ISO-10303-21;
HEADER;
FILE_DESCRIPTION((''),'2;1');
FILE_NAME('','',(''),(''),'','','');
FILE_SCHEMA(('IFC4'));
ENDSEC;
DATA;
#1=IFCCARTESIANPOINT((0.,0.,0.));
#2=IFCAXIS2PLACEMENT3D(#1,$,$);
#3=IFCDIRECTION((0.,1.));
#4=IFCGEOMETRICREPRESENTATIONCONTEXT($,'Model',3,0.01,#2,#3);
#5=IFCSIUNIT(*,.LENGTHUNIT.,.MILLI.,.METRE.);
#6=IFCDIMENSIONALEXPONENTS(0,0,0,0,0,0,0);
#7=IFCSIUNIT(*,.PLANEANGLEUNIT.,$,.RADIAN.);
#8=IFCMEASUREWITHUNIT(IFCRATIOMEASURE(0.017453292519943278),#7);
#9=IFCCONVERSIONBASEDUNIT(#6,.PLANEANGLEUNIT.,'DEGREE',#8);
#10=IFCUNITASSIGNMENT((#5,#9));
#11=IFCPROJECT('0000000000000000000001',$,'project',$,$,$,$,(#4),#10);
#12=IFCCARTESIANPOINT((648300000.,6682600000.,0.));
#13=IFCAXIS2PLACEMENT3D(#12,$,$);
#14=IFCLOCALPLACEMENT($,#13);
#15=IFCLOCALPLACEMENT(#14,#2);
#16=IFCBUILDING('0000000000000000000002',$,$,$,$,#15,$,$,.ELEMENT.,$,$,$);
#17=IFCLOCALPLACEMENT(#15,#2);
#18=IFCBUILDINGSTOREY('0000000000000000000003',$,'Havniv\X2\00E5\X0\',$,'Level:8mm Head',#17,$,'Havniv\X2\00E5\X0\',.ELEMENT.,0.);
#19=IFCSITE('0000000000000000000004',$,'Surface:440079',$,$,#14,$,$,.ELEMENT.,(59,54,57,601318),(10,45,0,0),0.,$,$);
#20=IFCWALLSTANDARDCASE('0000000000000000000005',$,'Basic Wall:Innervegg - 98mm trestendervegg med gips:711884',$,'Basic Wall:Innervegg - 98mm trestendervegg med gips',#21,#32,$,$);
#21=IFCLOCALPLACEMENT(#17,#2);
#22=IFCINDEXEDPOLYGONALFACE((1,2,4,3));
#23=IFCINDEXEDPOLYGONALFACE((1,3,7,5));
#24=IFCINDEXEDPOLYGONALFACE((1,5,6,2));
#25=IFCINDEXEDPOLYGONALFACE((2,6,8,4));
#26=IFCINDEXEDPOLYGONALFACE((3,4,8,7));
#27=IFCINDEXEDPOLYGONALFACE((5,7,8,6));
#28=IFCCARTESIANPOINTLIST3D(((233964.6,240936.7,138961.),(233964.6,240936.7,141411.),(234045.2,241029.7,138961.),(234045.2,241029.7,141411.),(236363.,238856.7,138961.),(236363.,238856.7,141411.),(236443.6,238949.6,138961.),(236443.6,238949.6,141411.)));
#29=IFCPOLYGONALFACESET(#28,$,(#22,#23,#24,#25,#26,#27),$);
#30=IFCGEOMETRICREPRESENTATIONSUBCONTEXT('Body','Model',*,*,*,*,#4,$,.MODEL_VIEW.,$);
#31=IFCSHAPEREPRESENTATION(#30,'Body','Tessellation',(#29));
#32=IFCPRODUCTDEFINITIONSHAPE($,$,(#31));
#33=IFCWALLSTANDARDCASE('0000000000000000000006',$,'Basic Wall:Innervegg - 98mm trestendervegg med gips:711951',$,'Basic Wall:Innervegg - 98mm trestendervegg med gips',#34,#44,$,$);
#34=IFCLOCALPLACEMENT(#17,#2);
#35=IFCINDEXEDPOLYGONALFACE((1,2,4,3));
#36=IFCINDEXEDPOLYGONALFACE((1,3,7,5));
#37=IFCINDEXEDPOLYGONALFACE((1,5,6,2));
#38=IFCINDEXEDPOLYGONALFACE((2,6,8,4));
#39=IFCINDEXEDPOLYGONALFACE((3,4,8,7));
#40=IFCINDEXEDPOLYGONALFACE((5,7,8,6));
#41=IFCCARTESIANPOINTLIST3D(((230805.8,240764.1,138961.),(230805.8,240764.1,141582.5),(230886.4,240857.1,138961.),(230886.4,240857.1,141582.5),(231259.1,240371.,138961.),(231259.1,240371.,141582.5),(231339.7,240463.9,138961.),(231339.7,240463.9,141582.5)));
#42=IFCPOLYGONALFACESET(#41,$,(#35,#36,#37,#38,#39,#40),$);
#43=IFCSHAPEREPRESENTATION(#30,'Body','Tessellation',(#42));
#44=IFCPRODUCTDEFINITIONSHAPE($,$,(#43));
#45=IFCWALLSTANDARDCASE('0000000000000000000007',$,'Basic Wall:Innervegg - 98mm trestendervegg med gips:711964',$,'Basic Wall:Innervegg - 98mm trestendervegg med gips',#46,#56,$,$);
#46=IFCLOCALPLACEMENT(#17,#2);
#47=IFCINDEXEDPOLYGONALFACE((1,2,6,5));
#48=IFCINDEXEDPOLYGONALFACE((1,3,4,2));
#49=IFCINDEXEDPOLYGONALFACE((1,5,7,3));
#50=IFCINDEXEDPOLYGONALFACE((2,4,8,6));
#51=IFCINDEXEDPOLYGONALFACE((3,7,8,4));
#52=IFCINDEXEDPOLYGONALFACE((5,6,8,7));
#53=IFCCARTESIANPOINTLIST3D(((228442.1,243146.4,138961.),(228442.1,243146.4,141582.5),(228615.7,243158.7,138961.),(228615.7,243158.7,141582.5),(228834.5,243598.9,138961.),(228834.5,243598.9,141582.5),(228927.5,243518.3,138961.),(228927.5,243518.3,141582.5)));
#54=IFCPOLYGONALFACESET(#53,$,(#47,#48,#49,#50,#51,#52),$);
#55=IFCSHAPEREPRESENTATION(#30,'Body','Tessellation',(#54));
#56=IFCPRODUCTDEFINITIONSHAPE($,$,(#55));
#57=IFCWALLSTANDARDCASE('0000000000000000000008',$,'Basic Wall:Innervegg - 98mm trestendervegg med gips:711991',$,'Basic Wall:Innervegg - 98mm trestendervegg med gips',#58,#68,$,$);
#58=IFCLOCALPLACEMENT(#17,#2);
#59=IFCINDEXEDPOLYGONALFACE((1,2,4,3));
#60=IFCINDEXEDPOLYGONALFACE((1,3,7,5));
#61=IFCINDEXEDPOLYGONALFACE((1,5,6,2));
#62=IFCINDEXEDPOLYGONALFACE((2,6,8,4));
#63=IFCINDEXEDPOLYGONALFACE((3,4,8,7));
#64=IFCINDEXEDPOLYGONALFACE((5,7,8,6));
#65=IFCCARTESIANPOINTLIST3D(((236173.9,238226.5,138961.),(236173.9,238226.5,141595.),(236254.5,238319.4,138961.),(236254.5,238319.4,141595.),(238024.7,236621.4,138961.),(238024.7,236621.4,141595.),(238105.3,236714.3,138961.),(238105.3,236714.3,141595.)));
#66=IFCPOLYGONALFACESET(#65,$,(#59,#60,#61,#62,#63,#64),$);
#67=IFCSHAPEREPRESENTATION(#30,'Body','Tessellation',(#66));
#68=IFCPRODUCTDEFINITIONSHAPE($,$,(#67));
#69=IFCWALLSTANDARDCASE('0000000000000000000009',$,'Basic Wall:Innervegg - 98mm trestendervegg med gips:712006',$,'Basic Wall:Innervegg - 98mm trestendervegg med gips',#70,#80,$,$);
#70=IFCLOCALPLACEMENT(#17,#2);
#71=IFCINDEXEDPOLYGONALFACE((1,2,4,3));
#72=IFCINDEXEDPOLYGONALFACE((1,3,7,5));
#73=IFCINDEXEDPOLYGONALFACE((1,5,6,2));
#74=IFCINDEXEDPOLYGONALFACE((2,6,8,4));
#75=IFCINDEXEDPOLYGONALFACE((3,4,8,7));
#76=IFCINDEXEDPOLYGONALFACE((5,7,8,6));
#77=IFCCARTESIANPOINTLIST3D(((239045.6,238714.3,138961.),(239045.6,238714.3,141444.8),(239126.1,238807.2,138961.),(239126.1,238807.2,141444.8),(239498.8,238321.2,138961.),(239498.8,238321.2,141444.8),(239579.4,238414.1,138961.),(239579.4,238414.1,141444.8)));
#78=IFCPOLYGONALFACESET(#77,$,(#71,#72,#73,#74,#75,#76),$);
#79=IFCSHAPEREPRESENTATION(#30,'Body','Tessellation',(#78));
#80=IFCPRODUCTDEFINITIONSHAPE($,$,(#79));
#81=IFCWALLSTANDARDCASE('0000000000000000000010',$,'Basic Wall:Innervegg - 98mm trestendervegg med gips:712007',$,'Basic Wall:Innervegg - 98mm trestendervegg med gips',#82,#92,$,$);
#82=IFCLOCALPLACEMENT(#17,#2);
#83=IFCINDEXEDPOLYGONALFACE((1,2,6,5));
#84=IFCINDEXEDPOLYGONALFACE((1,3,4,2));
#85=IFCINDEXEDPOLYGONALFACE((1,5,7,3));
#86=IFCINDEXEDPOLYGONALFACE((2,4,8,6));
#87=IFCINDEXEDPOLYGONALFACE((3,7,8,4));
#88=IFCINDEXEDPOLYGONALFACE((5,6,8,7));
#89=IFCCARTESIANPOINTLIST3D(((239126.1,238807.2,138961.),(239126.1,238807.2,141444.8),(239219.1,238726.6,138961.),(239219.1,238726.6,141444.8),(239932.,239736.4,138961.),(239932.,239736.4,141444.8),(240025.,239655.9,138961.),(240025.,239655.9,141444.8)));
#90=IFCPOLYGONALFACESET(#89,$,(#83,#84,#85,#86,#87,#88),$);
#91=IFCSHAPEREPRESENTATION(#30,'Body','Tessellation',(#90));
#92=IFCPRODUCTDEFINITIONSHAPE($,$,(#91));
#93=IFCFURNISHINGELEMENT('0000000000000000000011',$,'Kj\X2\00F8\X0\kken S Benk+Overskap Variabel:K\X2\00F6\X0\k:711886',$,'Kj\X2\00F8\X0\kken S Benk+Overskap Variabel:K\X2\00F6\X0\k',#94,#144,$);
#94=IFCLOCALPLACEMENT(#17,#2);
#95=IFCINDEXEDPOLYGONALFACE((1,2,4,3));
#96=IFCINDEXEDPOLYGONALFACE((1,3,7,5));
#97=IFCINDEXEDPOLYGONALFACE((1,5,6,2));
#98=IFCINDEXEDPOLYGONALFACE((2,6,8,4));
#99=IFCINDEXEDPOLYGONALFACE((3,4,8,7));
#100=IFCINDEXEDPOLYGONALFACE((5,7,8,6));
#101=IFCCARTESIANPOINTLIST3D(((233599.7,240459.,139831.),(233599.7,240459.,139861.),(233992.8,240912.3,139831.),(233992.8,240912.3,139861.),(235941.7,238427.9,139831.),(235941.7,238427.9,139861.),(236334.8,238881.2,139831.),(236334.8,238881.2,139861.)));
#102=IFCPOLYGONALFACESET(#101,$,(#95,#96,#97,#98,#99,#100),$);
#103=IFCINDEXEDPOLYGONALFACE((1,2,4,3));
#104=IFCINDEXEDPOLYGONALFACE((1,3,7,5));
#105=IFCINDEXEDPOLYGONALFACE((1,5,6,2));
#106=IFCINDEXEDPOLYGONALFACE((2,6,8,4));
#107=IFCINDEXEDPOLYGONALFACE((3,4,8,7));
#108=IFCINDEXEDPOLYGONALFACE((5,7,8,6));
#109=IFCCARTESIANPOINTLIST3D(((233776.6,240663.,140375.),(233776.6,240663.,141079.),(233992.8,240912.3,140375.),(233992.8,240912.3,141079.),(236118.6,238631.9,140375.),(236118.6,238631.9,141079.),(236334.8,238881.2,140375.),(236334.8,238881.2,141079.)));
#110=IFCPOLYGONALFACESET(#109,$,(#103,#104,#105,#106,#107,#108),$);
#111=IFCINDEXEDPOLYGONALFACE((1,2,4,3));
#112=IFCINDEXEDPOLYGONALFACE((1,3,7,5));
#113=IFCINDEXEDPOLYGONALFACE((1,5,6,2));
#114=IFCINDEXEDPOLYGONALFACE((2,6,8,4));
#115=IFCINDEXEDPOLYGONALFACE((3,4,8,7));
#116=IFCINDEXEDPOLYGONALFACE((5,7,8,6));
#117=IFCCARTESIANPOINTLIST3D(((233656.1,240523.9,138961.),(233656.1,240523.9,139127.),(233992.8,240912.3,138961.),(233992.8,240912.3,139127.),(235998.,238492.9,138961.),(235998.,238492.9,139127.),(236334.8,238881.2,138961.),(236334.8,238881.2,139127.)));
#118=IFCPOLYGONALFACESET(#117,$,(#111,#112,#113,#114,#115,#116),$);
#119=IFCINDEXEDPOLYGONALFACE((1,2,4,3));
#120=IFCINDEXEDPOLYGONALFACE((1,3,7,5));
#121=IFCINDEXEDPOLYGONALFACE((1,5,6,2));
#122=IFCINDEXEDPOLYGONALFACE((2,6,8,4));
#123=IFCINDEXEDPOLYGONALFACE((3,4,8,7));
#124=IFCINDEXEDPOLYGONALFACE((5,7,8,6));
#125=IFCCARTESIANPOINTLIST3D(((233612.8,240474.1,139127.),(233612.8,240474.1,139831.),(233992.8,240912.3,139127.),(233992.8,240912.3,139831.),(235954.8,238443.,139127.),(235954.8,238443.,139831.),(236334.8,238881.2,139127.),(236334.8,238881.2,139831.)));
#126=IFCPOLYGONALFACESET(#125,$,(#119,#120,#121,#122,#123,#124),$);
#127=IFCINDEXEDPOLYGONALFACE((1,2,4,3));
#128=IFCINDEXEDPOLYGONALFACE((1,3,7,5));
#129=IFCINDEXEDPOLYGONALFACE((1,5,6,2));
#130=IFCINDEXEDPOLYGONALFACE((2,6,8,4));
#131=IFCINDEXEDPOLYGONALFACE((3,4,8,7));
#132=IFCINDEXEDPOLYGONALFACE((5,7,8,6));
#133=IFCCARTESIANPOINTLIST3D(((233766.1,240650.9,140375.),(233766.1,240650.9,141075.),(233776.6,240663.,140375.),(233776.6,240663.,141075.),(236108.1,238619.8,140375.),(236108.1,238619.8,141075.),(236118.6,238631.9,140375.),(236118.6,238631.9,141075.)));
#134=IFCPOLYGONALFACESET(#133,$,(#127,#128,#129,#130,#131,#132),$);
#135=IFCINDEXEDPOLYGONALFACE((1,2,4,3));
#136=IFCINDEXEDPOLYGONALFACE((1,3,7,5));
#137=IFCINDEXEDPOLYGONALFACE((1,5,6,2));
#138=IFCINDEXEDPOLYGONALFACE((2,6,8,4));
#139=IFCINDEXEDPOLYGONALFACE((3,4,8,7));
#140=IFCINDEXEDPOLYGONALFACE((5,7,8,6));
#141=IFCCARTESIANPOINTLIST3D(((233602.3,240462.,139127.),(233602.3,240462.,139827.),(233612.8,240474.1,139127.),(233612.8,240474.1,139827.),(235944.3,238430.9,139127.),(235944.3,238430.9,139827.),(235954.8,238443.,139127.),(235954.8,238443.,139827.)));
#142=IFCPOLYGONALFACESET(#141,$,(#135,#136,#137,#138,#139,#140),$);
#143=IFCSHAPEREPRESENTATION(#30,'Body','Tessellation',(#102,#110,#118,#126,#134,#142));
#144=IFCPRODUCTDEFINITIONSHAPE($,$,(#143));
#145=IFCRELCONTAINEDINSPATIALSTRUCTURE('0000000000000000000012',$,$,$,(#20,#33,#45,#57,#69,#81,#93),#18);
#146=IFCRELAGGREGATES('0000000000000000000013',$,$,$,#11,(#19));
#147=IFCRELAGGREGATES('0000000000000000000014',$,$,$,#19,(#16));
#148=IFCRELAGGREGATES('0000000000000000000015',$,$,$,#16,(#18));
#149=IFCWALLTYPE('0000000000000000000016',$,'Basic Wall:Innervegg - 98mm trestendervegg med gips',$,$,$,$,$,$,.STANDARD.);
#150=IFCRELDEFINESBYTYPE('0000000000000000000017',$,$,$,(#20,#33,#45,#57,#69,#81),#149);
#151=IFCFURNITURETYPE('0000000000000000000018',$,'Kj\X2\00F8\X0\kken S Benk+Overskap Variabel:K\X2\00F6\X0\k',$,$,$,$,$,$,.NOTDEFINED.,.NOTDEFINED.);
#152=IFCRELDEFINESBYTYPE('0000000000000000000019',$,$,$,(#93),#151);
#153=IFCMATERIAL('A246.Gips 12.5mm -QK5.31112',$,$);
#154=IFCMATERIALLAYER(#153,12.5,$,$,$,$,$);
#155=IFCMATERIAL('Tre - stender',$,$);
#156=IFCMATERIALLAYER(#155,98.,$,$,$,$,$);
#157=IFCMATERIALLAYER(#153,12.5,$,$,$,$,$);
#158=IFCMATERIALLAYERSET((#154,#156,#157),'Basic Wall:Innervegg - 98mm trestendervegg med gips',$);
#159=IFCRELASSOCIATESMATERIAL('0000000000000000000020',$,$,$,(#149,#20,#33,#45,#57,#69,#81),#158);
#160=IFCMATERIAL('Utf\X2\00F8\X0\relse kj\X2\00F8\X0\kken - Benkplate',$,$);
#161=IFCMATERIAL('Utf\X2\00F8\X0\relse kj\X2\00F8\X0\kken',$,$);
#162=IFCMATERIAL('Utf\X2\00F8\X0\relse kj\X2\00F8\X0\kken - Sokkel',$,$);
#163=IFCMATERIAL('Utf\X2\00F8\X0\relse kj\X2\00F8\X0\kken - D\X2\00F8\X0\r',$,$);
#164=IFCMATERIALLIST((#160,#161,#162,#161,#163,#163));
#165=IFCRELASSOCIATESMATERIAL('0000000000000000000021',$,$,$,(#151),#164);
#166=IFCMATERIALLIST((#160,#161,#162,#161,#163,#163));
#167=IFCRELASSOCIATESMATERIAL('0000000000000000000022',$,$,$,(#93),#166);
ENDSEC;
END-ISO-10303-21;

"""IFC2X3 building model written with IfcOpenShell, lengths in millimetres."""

from ifc_helpers import new_model, entity, si_unit, converted_unit, direction, frame, frame_2d, origin, origin_2d_with_axis, place, context, subcontext, project, spatial, polyline, rectangle, outline, extrude, source, transform, mapped, material, material_list, layer, layer_set, layer_usage, type_object, type_shapes, element, save


model = new_model("IFC2X3")

# Units and contexts
model_context = context("Model", 3, precision=0.01, world=origin(), true_north=direction((0.0, 1.0)))
body_context = subcontext(model_context, "Body", "Model", "MODEL_VIEW")
ifc_project = project(units=[si_unit("LENGTHUNIT", "METRE", prefix="MILLI"), converted_unit("PLANEANGLEUNIT", "DEGREE", entity("IfcRatioMeasure", 0.017453292519943278), si_unit("PLANEANGLEUNIT", "RADIAN"), dimensions=[0, 0, 0, 0, 0, 0, 0])], contexts=[model_context])

# Site, building, storey
site_placement = place(None, frame((648300000.0, 6682600000.0, 0.0)))
site = spatial("IfcSite", under=ifc_project, at=site_placement, Name="Surface:440079", CompositionType="ELEMENT", RefLatitude=(59, 54, 57, 601318), RefLongitude=(10, 45, 0, 0), RefElevation=0.0)
building_placement = place(site_placement, origin())
building = spatial("IfcBuilding", under=site, at=building_placement, CompositionType="ELEMENT")
storey_placement = place(building_placement, origin())
storey = spatial("IfcBuildingStorey", under=building, at=storey_placement, Name="Havnivå", ObjectType="Level:8mm Head", LongName="Havnivå", CompositionType="ELEMENT", Elevation=0.0)

# Shared definitions
ifc_material_1 = material(Name="A246.Gips 12.5mm -QK5.31112")
ifc_layer_1 = layer(ifc_material_1, 12.5)
ifc_material_2 = material(Name="Tre - stender")
ifc_layer_2 = layer(ifc_material_2, 98.0)
ifc_layer_3 = layer(ifc_material_1, 12.5)
ifc_layer_set = layer_set([ifc_layer_1, ifc_layer_2, ifc_layer_3], Name="Basic Wall:Innervegg - 98mm trestendervegg med gips")
wall_type = type_object("IfcWallType", Name="Basic Wall:Innervegg - 98mm trestendervegg med gips", PredefinedType="STANDARD", material=ifc_layer_set)

# Walls
ifc_layer_usage_1 = layer_usage(ifc_layer_set, "AXIS2", "NEGATIVE", 61.5)
wall_1_placement = place(storey_placement, frame((234004.9, 240983.2, 138961.0), z_axis=(0.0, 0.0, 1.0), x_axis=(0.755467, -0.655187, 0.0)))
element("IfcWallStandardCase", 1, at=wall_1_placement, inside=storey, type_object=wall_type, material=ifc_layer_usage_1, Name="Basic Wall:Innervegg - 98mm trestendervegg med gips:711884", ObjectType="Basic Wall:Innervegg - 98mm trestendervegg med gips", context=body_context, shape_type="SweptSolid", body=[
    extrude(rectangle(XDim=3174.7, YDim=123.0, at=frame_2d((1587.4, 0.0), x_axis=(-1.0, 0.0))), origin(), (0.0, 0.0, 1.0), 2450.0),
])
ifc_layer_usage_2 = layer_usage(ifc_layer_set, "AXIS2", "NEGATIVE", 61.5)
wall_2_placement = place(storey_placement, frame((231299.4, 240417.5, 138961.0), z_axis=(0.0, 0.0, 1.0), x_axis=(-0.755467, 0.655187, 0.0)))
element("IfcWallStandardCase", 2, at=wall_2_placement, inside=storey, type_object=wall_type, material=ifc_layer_usage_2, Name="Basic Wall:Innervegg - 98mm trestendervegg med gips:711951", ObjectType="Basic Wall:Innervegg - 98mm trestendervegg med gips", context=body_context, shape_type="SweptSolid", body=[
    extrude(rectangle(XDim=600.0, YDim=123.0, at=frame_2d((300.0, 0.0), x_axis=(-1.0, 0.0))), origin(), (0.0, 0.0, 1.0), 2621.5),
])
ifc_layer_usage_3 = layer_usage(ifc_layer_set, "AXIS2", "NEGATIVE", 61.5)
wall_3_placement = place(storey_placement, frame((228881.0, 243558.6, 138961.0), z_axis=(0.0, 0.0, 1.0), x_axis=(-0.655187, -0.755467, 0.0)))
element("IfcWallStandardCase", 3, at=wall_3_placement, inside=storey, type_object=wall_type, material=ifc_layer_usage_3, Name="Basic Wall:Innervegg - 98mm trestendervegg med gips:711964", ObjectType="Basic Wall:Innervegg - 98mm trestendervegg med gips", context=body_context, shape_type="SweptSolid", body=[
    extrude(outline(polyline([(598.9, -61.5), (475.9, 61.5), (0.0, 61.5), (0.0, -61.5), (598.9, -61.5)])), origin(), (0.0, 0.0, 1.0), 2621.5),
])
ifc_layer_usage_4 = layer_usage(ifc_layer_set, "AXIS2", "NEGATIVE", 61.5)
wall_4_placement = place(storey_placement, frame((238065.0, 236667.8, 138961.0), z_axis=(0.0, 0.0, 1.0), x_axis=(-0.755467, 0.655187, 0.0)))
element("IfcWallStandardCase", 4, at=wall_4_placement, inside=storey, type_object=wall_type, material=ifc_layer_usage_4, Name="Basic Wall:Innervegg - 98mm trestendervegg med gips:711991", ObjectType="Basic Wall:Innervegg - 98mm trestendervegg med gips", context=body_context, shape_type="SweptSolid", body=[
    extrude(rectangle(XDim=2449.9, YDim=123.0, at=frame_2d((1224.9, 0.0), x_axis=(-1.0, 0.0))), origin(), (0.0, 0.0, 1.0), 2634.0),
])

# Walls
ifc_layer_usage_5 = layer_usage(ifc_layer_set, "AXIS2", "POSITIVE", -61.5)
wall_5_placement = place(storey_placement, frame((239539.1, 238367.6, 138961.0), z_axis=(0.0, 0.0, 1.0), x_axis=(-0.755467, 0.655187, 0.0)))
element("IfcWallStandardCase", 5, at=wall_5_placement, inside=storey, type_object=wall_type, material=ifc_layer_usage_5, Name="Basic Wall:Innervegg - 98mm trestendervegg med gips:712006", ObjectType="Basic Wall:Innervegg - 98mm trestendervegg med gips", context=body_context, shape_type="SweptSolid", body=[
    extrude(rectangle(XDim=600.0, YDim=123.0, at=frame_2d((300.0, 0.0), x_axis=(-1.0, 0.0))), origin(), (0.0, 0.0, 1.0), 2483.8),
])
ifc_layer_usage_6 = layer_usage(ifc_layer_set, "AXIS2", "POSITIVE", -61.5)
wall_6_placement = place(storey_placement, frame((239172.6, 238766.9, 138961.0), z_axis=(0.0, 0.0, 1.0), x_axis=(0.655187, 0.755467, 0.0)))
element("IfcWallStandardCase", 6, at=wall_6_placement, inside=storey, type_object=wall_type, material=ifc_layer_usage_6, Name="Basic Wall:Innervegg - 98mm trestendervegg med gips:712007", ObjectType="Basic Wall:Innervegg - 98mm trestendervegg med gips", context=body_context, shape_type="SweptSolid", body=[
    extrude(rectangle(XDim=1230.0, YDim=123.0, at=frame_2d((615.0, 0.0), x_axis=(-1.0, 0.0))), origin(), (0.0, 0.0, 1.0), 2483.8),
])

# Furnishing element
ifc_material_3 = material(Name="Utførelse kjøkken - Benkplate")
ifc_material_4 = material(Name="Utførelse kjøkken")
ifc_material_5 = material(Name="Utførelse kjøkken - Sokkel")
ifc_material_6 = material(Name="Utførelse kjøkken - Dør")
ifc_material_list_1 = material_list([ifc_material_3, ifc_material_4, ifc_material_5, ifc_material_4, ifc_material_6, ifc_material_6])
ifc_material_list_2 = material_list([ifc_material_3, ifc_material_4, ifc_material_5, ifc_material_4, ifc_material_6, ifc_material_6])
furniture_type_1 = type_object("IfcFurnitureType", Name="Kjøkken S Benk+Overskap Variabel:Kök", material=ifc_material_list_2)
shared_shape_1 = source(origin(), body_context, "Body", "SweptSolid", [
    extrude(rectangle(XDim=3100.0, YDim=600.0, at=origin_2d_with_axis()), frame((1550.0, -300.0, 870.0), z_axis=(0.0, 0.0, 1.0), x_axis=(-1.0, 0.0, 0.0)), (0.0, 0.0, 1.0), 30.0),
    extrude(rectangle(XDim=3100.0, YDim=330.0, at=origin_2d_with_axis()), frame((1550.0, -165.0, 1414.0), z_axis=(0.0, 0.0, 1.0), x_axis=(-1.0, 0.0, 0.0)), (0.0, 0.0, 1.0), 704.0),
    extrude(rectangle(XDim=3100.0, YDim=514.0, at=origin_2d_with_axis()), frame((1550.0, -257.0, 0.0), z_axis=(0.0, 0.0, 1.0), x_axis=(-1.0, 0.0, 0.0)), (0.0, 0.0, 1.0), 166.0),
    extrude(rectangle(XDim=3100.0, YDim=580.0, at=origin_2d_with_axis()), frame((1550.0, -290.0, 166.0), z_axis=(0.0, 0.0, 1.0), x_axis=(-1.0, 0.0, 0.0)), (0.0, 0.0, 1.0), 704.0),
    extrude(rectangle(XDim=3100.0, YDim=16.0, at=origin_2d_with_axis()), frame((1550.0, -338.0, 1414.0)), (0.0, 0.0, 1.0), 700.0),
    extrude(rectangle(XDim=3100.0, YDim=16.0, at=frame_2d((0.0, 0.0), x_axis=(1.0, 0.0))), frame((1550.0, -588.0, 166.0)), (0.0, 0.0, 1.0), 700.0),
])
type_shapes(furniture_type_1, [shared_shape_1])
furnishing_1_placement = place(storey_placement, frame((233992.8, 240912.3, 138961.0), z_axis=(0.0, 0.0, 1.0), x_axis=(0.755467, -0.655187, 0.0)))
element("IfcFurnishingElement", 7, at=furnishing_1_placement, inside=storey, type_object=furniture_type_1, material=ifc_material_list_1, Name="Kjøkken S Benk+Overskap Variabel:Kök:711886", ObjectType="Kjøkken S Benk+Overskap Variabel:Kök", context=body_context, shape_type="MappedRepresentation", body=[
    mapped(shared_shape_1, transform((0.0, 0.0, 0.0), scale=1.0)),
])

save(model, "model.ifc")
